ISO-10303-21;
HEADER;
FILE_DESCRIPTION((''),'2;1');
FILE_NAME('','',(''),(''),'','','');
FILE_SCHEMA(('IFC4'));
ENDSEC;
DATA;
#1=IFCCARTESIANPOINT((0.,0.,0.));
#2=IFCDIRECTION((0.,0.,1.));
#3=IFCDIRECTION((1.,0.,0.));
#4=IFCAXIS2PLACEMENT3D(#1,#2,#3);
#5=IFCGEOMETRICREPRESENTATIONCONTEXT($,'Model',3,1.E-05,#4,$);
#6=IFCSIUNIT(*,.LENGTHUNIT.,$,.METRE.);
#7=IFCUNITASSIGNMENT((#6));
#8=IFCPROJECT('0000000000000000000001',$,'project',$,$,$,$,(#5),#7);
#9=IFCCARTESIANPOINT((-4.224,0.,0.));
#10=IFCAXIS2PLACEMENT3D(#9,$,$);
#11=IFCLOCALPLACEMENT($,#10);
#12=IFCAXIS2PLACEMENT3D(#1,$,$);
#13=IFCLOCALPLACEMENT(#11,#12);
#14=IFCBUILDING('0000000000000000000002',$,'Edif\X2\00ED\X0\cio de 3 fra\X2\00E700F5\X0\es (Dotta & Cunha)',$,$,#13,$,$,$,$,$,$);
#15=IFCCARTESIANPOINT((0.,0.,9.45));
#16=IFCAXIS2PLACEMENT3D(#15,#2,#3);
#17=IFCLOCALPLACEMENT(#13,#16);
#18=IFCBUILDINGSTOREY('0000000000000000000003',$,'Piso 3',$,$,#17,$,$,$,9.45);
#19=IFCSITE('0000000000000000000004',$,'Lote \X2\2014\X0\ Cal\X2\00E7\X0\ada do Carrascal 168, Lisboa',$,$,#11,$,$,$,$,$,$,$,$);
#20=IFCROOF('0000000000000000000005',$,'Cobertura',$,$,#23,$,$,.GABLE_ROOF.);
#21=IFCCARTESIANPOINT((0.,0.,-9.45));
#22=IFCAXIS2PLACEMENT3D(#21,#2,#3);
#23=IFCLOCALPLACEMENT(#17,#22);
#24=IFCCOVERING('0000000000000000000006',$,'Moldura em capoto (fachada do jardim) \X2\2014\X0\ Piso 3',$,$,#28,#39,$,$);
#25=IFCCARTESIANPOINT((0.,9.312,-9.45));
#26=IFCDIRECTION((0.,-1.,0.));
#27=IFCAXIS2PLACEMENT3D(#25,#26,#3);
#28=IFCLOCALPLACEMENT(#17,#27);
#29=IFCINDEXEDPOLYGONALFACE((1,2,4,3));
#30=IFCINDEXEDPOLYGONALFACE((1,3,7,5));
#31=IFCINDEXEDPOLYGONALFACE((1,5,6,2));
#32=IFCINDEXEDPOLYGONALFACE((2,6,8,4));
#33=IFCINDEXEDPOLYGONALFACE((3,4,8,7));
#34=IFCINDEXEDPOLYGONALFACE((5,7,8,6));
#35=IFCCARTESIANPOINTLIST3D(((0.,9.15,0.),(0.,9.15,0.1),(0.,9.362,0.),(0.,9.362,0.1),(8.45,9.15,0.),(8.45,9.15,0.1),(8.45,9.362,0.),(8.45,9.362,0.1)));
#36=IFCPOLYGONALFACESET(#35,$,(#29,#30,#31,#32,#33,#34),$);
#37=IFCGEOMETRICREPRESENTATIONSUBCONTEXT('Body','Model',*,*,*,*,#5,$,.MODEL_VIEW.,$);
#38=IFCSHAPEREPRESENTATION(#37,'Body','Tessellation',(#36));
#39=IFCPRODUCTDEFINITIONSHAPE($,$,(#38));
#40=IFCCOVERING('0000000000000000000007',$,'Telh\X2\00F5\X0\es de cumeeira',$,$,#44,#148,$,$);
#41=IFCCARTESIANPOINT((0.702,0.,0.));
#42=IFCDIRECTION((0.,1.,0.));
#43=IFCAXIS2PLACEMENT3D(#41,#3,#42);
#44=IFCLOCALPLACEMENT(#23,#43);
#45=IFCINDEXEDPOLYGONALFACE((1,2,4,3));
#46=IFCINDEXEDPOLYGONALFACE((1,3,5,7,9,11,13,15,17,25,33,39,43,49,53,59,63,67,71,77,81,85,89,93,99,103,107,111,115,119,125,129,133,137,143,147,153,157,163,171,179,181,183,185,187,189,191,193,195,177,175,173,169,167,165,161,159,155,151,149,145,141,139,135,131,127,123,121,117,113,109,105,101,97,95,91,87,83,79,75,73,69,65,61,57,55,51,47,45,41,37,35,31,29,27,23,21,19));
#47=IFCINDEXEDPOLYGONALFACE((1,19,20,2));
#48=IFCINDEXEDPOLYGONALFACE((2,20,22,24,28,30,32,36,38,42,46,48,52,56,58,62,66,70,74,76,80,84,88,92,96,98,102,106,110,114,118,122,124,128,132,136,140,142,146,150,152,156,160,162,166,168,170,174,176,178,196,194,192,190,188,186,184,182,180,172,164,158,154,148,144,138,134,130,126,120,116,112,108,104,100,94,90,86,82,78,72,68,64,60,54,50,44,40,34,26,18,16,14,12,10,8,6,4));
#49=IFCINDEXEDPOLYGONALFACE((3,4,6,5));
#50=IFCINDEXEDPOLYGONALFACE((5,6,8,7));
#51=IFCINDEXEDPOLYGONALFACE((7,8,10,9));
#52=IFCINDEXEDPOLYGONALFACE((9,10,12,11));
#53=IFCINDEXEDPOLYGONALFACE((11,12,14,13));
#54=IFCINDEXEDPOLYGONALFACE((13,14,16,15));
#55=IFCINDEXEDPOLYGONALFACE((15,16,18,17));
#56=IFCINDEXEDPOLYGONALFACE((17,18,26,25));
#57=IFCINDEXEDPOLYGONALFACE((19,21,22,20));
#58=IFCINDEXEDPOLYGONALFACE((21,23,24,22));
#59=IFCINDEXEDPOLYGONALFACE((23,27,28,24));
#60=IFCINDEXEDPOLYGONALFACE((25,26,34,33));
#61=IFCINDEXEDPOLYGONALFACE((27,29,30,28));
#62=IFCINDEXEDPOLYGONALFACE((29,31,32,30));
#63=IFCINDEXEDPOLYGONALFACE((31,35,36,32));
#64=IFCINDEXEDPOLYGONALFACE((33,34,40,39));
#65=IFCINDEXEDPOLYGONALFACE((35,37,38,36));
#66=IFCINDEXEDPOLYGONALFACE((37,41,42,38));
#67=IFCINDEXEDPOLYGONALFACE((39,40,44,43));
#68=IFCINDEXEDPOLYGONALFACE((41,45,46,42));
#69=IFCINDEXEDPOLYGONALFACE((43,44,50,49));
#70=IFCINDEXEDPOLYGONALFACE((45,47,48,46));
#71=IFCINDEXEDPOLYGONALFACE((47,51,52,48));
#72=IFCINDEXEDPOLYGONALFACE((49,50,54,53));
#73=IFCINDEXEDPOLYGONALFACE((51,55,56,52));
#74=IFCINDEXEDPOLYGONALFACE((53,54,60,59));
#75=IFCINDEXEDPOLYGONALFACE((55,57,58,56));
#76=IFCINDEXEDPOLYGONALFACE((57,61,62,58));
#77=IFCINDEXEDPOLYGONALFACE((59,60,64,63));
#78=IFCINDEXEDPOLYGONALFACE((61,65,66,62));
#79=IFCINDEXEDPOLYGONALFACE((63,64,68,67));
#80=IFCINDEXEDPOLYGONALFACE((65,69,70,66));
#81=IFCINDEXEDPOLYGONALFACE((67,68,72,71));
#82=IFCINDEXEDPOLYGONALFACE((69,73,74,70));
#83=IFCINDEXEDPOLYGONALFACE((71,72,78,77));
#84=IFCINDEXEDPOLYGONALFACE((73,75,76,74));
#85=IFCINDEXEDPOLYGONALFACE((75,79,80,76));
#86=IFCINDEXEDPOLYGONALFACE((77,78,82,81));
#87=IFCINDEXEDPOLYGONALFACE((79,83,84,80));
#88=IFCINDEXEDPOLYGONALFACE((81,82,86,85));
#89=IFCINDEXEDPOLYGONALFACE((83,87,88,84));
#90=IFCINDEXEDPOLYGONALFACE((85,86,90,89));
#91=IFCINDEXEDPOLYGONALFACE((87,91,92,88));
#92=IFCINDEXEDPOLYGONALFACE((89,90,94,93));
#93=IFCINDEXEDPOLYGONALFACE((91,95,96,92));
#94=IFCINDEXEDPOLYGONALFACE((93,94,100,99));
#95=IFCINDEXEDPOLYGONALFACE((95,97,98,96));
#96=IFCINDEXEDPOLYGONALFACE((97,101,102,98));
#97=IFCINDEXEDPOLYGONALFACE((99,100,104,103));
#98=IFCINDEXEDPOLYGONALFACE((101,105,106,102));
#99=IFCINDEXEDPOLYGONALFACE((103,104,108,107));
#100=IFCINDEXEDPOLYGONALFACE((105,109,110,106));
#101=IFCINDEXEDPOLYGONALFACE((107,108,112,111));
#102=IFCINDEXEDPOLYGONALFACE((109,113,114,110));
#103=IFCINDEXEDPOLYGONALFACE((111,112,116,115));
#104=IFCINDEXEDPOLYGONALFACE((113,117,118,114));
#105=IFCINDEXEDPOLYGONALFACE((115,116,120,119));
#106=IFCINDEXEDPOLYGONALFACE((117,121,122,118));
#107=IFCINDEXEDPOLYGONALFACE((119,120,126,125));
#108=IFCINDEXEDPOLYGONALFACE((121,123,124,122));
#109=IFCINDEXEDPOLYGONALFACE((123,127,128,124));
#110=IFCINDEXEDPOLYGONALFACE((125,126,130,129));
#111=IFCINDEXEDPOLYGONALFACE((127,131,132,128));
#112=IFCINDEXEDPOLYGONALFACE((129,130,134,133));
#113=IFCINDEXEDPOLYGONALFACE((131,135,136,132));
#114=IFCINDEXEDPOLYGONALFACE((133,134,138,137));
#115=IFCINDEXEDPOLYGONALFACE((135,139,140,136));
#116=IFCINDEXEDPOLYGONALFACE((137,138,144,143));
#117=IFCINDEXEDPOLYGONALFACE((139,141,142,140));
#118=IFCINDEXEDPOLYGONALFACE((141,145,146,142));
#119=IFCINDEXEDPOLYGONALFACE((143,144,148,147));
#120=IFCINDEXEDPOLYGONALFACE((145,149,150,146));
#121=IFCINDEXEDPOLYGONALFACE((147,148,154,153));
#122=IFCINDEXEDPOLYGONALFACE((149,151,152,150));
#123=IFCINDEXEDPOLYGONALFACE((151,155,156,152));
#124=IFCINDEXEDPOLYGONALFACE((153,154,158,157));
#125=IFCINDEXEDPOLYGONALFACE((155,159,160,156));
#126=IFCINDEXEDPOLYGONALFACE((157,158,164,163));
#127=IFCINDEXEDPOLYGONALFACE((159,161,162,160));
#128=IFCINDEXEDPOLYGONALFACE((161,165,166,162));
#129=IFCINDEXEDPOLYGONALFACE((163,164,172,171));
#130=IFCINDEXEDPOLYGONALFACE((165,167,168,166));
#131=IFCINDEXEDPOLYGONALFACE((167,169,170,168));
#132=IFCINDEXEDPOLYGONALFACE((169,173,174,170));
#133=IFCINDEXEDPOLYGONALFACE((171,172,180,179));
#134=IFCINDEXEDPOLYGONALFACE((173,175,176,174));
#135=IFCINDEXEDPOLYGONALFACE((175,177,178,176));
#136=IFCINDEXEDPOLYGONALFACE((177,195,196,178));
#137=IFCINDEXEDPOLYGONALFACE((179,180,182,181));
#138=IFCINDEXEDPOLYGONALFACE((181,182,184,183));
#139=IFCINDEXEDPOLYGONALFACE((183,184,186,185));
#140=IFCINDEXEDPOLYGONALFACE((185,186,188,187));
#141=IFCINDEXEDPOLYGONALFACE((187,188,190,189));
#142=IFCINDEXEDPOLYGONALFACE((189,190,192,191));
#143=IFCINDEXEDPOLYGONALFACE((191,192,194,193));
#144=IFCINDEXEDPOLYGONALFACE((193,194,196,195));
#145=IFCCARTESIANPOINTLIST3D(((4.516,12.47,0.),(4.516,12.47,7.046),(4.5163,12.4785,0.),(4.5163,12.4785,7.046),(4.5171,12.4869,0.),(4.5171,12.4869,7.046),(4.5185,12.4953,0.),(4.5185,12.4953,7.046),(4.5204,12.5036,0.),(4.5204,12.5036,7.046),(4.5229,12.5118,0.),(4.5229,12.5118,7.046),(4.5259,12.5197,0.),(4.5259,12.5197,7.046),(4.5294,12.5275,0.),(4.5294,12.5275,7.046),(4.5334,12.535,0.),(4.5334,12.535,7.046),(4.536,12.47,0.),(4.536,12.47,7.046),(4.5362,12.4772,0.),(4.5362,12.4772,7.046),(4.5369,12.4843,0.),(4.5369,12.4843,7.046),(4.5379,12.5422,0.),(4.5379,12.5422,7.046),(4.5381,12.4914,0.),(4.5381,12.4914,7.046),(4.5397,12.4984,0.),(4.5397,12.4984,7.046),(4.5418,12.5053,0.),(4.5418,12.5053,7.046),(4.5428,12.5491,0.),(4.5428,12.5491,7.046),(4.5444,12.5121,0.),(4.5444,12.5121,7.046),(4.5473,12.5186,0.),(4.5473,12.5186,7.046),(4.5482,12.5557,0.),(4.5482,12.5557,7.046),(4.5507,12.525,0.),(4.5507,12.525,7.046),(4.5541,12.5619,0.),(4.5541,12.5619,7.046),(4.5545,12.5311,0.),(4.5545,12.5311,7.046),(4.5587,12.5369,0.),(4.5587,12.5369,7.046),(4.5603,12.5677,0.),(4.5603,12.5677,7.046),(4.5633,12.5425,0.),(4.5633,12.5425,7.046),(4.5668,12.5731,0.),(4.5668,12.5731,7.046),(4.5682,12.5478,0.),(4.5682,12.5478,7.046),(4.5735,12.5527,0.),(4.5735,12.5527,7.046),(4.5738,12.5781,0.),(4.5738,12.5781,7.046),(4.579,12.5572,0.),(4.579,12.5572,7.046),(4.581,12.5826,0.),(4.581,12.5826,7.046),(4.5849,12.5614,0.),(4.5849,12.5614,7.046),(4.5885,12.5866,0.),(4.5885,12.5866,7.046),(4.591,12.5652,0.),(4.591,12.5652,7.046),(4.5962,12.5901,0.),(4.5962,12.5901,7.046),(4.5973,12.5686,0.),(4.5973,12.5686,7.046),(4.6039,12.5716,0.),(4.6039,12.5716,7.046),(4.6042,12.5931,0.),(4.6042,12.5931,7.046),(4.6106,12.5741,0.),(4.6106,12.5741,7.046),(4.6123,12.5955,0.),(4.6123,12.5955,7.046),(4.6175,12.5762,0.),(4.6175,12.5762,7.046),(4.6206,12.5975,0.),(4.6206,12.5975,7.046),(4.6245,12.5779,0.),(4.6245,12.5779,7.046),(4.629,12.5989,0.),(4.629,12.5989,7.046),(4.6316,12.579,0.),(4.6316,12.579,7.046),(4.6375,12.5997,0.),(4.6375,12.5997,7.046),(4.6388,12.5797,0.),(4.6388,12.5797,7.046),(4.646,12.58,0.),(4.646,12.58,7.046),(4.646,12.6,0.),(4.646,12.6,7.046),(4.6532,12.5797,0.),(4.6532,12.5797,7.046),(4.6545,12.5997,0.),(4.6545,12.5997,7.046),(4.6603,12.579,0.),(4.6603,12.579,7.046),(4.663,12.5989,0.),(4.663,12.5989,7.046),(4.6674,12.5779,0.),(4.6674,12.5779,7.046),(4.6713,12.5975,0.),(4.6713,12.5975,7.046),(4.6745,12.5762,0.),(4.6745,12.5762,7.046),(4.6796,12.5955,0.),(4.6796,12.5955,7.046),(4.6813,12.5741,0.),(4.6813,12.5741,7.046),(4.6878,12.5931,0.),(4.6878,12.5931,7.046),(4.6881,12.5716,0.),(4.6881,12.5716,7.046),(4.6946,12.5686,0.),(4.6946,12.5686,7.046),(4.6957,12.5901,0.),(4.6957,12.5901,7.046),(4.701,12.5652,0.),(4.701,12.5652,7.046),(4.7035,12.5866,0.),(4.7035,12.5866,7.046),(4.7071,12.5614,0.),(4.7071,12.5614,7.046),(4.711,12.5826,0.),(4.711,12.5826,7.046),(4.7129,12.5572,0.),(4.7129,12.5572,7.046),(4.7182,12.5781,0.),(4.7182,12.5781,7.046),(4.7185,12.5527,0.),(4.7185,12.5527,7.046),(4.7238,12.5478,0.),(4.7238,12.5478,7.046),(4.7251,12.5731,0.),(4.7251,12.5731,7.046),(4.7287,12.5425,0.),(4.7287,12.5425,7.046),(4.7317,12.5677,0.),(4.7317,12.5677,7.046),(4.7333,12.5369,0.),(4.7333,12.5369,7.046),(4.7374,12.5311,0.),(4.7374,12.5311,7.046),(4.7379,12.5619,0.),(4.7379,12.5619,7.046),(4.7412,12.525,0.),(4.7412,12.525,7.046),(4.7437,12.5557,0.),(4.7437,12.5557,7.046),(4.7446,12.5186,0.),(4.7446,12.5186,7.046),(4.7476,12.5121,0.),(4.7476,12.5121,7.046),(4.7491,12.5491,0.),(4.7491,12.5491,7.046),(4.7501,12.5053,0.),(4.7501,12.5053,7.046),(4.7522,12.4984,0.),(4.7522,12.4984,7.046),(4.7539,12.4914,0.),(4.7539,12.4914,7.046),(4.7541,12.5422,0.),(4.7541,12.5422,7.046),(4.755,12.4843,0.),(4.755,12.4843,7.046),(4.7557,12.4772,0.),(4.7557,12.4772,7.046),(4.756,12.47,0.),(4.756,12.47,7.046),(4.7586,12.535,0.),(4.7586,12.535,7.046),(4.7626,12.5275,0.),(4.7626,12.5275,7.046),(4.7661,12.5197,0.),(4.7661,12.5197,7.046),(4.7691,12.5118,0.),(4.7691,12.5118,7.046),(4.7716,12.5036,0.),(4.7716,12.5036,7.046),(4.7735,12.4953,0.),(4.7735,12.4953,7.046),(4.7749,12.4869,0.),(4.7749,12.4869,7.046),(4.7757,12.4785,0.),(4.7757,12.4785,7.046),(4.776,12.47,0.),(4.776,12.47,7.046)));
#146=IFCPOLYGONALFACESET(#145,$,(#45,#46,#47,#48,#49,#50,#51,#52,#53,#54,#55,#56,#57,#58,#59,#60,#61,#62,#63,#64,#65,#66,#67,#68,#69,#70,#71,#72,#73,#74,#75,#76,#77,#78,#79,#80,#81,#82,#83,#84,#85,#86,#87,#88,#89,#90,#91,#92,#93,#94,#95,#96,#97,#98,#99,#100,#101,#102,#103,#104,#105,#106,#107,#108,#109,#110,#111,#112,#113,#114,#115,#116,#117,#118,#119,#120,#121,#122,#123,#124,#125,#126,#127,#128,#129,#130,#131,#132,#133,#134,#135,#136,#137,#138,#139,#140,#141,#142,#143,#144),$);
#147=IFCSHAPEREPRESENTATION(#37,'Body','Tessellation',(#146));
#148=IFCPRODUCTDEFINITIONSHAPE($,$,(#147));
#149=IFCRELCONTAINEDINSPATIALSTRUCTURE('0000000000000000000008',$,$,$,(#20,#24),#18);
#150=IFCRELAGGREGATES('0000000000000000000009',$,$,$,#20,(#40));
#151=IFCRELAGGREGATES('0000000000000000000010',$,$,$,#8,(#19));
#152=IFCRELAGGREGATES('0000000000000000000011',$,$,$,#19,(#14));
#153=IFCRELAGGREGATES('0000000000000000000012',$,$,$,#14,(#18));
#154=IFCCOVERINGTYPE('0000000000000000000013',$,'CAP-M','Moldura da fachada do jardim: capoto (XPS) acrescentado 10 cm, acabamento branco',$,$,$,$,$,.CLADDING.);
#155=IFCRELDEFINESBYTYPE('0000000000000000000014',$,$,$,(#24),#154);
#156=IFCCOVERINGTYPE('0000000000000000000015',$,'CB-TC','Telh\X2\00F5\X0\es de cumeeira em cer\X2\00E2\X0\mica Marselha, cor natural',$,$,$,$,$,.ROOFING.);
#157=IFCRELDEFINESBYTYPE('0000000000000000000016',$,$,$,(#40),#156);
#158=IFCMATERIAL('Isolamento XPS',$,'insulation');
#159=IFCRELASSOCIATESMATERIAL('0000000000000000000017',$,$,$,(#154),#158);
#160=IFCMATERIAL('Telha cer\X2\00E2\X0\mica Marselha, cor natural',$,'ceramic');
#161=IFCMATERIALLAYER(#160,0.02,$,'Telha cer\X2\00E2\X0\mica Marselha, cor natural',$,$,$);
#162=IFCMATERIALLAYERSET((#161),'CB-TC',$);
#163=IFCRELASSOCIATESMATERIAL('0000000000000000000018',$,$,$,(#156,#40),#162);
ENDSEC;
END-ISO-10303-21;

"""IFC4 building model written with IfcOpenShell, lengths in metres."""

from ifc_helpers import new_model, si_unit, frame, origin, origin_with_axes, place, context, subcontext, project, spatial, line, indexed_curve, outline, extrude, material, layer, layer_set, layer_usage, type_object, element, aggregate, save


model = new_model("IFC4")

# Units and contexts
model_context = context("Model", 3, precision=1e-05, world=origin_with_axes())
body_context = subcontext(model_context, "Body", "Model", "MODEL_VIEW")
ifc_project = project(units=[si_unit("LENGTHUNIT", "METRE")], contexts=[model_context])

# Site, building, storey
site_placement = place(None, frame((-4.224, 0.0, 0.0)))
site = spatial("IfcSite", under=ifc_project, at=site_placement, Name="Lote — Calçada do Carrascal 168, Lisboa")
building_placement = place(site_placement, origin())
building = spatial("IfcBuilding", under=site, at=building_placement, Name="Edifício de 3 frações (Dotta & Cunha)")
storey_placement = place(building_placement, frame((0.0, 0.0, 9.45), z_axis=(0.0, 0.0, 1.0), x_axis=(1.0, 0.0, 0.0)))
storey = spatial("IfcBuildingStorey", under=building, at=storey_placement, Name="Piso 3", Elevation=9.45)

# Roof
roof_placement = place(storey_placement, frame((0.0, 0.0, -9.45), z_axis=(0.0, 0.0, 1.0), x_axis=(1.0, 0.0, 0.0)))
roof = element("IfcRoof", 1, at=roof_placement, inside=storey, Name="Cobertura", PredefinedType="GABLE_ROOF")

# Covering
ifc_material_1 = material(Name="Isolamento XPS", Category="insulation")
covering_type_1 = type_object("IfcCoveringType", Name="CAP-M", Description="Moldura da fachada do jardim: capoto (XPS) acrescentado 10 cm, acabamento branco", PredefinedType="CLADDING", material=ifc_material_1)
covering_1_placement = place(storey_placement, frame((0.0, 9.312, -9.45), z_axis=(0.0, -1.0, 0.0), x_axis=(1.0, 0.0, 0.0)))
element("IfcCovering", 2, at=covering_1_placement, inside=storey, type_object=covering_type_1, Name="Moldura em capoto (fachada do jardim) — Piso 3", context=body_context, shape_type="SweptSolid", body=[
    extrude(outline(indexed_curve([(8.45, 9.15), (0.0, 9.15), (0.0, 9.362), (8.45, 9.362)], segments=[line(1, 2, 3, 4, 1)])), origin_with_axes(), (0.0, 0.0, 1.0), 0.1),
])

# Shared definitions
ifc_material_2 = material(Name="Telha cerâmica Marselha, cor natural", Category="ceramic")

# Covering
ifc_layer_1 = layer(ifc_material_2, 0.02, Name="Telha cerâmica Marselha, cor natural")
ifc_layer_set_1 = layer_set([ifc_layer_1], Name="CB-TC")
ifc_layer_usage_1 = layer_usage(ifc_layer_set_1, "AXIS3", "POSITIVE", 0.0)
covering_type_2 = type_object("IfcCoveringType", Name="CB-TC", Description="Telhões de cumeeira em cerâmica Marselha, cor natural", PredefinedType="ROOFING", material=ifc_layer_set_1)
covering_2_placement = place(roof_placement, frame((0.702, 0.0, 0.0), z_axis=(1.0, 0.0, 0.0), x_axis=(0.0, 1.0, 0.0)))
covering_2 = element("IfcCovering", 3, at=covering_2_placement, type_object=covering_type_2, material=ifc_layer_usage_1, Name="Telhões de cumeeira", context=body_context, shape_type="SweptSolid", body=[
    extrude(outline(indexed_curve([(4.5163, 12.4785), (4.5171, 12.4869), (4.5185, 12.4953), (4.5204, 12.5036), (4.5229, 12.5118), (4.5259, 12.5197), (4.5294, 12.5275), (4.5334, 12.535), (4.5379, 12.5422), (4.5428, 12.5491), (4.5482, 12.5557), (4.5541, 12.5619), (4.5603, 12.5677), (4.5668, 12.5731), (4.5738, 12.5781), (4.581, 12.5826), (4.5885, 12.5866), (4.5962, 12.5901), (4.6042, 12.5931), (4.6123, 12.5955), (4.6206, 12.5975), (4.629, 12.5989), (4.6375, 12.5997), (4.646, 12.6), (4.6545, 12.5997), (4.663, 12.5989), (4.6713, 12.5975), (4.6796, 12.5955), (4.6878, 12.5931), (4.6957, 12.5901), (4.7035, 12.5866), (4.711, 12.5826), (4.7182, 12.5781), (4.7251, 12.5731), (4.7317, 12.5677), (4.7379, 12.5619), (4.7437, 12.5557), (4.7491, 12.5491), (4.7541, 12.5422), (4.7586, 12.535), (4.7626, 12.5275), (4.7661, 12.5197), (4.7691, 12.5118), (4.7716, 12.5036), (4.7735, 12.4953), (4.7749, 12.4869), (4.7757, 12.4785), (4.776, 12.47), (4.756, 12.47), (4.7557, 12.4772), (4.755, 12.4843), (4.7539, 12.4914), (4.7522, 12.4984), (4.7501, 12.5053), (4.7476, 12.5121), (4.7446, 12.5186), (4.7412, 12.525), (4.7374, 12.5311), (4.7333, 12.5369), (4.7287, 12.5425), (4.7238, 12.5478), (4.7185, 12.5527), (4.7129, 12.5572), (4.7071, 12.5614), (4.701, 12.5652), (4.6946, 12.5686), (4.6881, 12.5716), (4.6813, 12.5741), (4.6745, 12.5762), (4.6674, 12.5779), (4.6603, 12.579), (4.6532, 12.5797), (4.646, 12.58), (4.6388, 12.5797), (4.6316, 12.579), (4.6245, 12.5779), (4.6175, 12.5762), (4.6106, 12.5741), (4.6039, 12.5716), (4.5973, 12.5686), (4.591, 12.5652), (4.5849, 12.5614), (4.579, 12.5572), (4.5735, 12.5527), (4.5682, 12.5478), (4.5633, 12.5425), (4.5587, 12.5369), (4.5545, 12.5311), (4.5507, 12.525), (4.5473, 12.5186), (4.5444, 12.5121), (4.5418, 12.5053), (4.5397, 12.4984), (4.5381, 12.4914), (4.5369, 12.4843), (4.5362, 12.4772), (4.536, 12.47), (4.516, 12.47)], segments=[line(1, 2, 3, 4, 5, 6, 7, 8, 9, 10, 11, 12, 13, 14, 15, 16, 17, 18, 19, 20, 21, 22, 23, 24, 25, 26, 27, 28, 29, 30, 31, 32, 33, 34, 35, 36, 37, 38, 39, 40, 41, 42, 43, 44, 45, 46, 47, 48, 49, 50, 51, 52, 53, 54, 55, 56, 57, 58, 59, 60, 61, 62, 63, 64, 65, 66, 67, 68, 69, 70, 71, 72, 73, 74, 75, 76, 77, 78, 79, 80, 81, 82, 83, 84, 85, 86, 87, 88, 89, 90, 91, 92, 93, 94, 95, 96, 97, 98, 1)])), origin_with_axes(), (0.0, 0.0, 1.0), 7.046),
])
aggregate(roof, [covering_2])

save(model, "model.ifc")
